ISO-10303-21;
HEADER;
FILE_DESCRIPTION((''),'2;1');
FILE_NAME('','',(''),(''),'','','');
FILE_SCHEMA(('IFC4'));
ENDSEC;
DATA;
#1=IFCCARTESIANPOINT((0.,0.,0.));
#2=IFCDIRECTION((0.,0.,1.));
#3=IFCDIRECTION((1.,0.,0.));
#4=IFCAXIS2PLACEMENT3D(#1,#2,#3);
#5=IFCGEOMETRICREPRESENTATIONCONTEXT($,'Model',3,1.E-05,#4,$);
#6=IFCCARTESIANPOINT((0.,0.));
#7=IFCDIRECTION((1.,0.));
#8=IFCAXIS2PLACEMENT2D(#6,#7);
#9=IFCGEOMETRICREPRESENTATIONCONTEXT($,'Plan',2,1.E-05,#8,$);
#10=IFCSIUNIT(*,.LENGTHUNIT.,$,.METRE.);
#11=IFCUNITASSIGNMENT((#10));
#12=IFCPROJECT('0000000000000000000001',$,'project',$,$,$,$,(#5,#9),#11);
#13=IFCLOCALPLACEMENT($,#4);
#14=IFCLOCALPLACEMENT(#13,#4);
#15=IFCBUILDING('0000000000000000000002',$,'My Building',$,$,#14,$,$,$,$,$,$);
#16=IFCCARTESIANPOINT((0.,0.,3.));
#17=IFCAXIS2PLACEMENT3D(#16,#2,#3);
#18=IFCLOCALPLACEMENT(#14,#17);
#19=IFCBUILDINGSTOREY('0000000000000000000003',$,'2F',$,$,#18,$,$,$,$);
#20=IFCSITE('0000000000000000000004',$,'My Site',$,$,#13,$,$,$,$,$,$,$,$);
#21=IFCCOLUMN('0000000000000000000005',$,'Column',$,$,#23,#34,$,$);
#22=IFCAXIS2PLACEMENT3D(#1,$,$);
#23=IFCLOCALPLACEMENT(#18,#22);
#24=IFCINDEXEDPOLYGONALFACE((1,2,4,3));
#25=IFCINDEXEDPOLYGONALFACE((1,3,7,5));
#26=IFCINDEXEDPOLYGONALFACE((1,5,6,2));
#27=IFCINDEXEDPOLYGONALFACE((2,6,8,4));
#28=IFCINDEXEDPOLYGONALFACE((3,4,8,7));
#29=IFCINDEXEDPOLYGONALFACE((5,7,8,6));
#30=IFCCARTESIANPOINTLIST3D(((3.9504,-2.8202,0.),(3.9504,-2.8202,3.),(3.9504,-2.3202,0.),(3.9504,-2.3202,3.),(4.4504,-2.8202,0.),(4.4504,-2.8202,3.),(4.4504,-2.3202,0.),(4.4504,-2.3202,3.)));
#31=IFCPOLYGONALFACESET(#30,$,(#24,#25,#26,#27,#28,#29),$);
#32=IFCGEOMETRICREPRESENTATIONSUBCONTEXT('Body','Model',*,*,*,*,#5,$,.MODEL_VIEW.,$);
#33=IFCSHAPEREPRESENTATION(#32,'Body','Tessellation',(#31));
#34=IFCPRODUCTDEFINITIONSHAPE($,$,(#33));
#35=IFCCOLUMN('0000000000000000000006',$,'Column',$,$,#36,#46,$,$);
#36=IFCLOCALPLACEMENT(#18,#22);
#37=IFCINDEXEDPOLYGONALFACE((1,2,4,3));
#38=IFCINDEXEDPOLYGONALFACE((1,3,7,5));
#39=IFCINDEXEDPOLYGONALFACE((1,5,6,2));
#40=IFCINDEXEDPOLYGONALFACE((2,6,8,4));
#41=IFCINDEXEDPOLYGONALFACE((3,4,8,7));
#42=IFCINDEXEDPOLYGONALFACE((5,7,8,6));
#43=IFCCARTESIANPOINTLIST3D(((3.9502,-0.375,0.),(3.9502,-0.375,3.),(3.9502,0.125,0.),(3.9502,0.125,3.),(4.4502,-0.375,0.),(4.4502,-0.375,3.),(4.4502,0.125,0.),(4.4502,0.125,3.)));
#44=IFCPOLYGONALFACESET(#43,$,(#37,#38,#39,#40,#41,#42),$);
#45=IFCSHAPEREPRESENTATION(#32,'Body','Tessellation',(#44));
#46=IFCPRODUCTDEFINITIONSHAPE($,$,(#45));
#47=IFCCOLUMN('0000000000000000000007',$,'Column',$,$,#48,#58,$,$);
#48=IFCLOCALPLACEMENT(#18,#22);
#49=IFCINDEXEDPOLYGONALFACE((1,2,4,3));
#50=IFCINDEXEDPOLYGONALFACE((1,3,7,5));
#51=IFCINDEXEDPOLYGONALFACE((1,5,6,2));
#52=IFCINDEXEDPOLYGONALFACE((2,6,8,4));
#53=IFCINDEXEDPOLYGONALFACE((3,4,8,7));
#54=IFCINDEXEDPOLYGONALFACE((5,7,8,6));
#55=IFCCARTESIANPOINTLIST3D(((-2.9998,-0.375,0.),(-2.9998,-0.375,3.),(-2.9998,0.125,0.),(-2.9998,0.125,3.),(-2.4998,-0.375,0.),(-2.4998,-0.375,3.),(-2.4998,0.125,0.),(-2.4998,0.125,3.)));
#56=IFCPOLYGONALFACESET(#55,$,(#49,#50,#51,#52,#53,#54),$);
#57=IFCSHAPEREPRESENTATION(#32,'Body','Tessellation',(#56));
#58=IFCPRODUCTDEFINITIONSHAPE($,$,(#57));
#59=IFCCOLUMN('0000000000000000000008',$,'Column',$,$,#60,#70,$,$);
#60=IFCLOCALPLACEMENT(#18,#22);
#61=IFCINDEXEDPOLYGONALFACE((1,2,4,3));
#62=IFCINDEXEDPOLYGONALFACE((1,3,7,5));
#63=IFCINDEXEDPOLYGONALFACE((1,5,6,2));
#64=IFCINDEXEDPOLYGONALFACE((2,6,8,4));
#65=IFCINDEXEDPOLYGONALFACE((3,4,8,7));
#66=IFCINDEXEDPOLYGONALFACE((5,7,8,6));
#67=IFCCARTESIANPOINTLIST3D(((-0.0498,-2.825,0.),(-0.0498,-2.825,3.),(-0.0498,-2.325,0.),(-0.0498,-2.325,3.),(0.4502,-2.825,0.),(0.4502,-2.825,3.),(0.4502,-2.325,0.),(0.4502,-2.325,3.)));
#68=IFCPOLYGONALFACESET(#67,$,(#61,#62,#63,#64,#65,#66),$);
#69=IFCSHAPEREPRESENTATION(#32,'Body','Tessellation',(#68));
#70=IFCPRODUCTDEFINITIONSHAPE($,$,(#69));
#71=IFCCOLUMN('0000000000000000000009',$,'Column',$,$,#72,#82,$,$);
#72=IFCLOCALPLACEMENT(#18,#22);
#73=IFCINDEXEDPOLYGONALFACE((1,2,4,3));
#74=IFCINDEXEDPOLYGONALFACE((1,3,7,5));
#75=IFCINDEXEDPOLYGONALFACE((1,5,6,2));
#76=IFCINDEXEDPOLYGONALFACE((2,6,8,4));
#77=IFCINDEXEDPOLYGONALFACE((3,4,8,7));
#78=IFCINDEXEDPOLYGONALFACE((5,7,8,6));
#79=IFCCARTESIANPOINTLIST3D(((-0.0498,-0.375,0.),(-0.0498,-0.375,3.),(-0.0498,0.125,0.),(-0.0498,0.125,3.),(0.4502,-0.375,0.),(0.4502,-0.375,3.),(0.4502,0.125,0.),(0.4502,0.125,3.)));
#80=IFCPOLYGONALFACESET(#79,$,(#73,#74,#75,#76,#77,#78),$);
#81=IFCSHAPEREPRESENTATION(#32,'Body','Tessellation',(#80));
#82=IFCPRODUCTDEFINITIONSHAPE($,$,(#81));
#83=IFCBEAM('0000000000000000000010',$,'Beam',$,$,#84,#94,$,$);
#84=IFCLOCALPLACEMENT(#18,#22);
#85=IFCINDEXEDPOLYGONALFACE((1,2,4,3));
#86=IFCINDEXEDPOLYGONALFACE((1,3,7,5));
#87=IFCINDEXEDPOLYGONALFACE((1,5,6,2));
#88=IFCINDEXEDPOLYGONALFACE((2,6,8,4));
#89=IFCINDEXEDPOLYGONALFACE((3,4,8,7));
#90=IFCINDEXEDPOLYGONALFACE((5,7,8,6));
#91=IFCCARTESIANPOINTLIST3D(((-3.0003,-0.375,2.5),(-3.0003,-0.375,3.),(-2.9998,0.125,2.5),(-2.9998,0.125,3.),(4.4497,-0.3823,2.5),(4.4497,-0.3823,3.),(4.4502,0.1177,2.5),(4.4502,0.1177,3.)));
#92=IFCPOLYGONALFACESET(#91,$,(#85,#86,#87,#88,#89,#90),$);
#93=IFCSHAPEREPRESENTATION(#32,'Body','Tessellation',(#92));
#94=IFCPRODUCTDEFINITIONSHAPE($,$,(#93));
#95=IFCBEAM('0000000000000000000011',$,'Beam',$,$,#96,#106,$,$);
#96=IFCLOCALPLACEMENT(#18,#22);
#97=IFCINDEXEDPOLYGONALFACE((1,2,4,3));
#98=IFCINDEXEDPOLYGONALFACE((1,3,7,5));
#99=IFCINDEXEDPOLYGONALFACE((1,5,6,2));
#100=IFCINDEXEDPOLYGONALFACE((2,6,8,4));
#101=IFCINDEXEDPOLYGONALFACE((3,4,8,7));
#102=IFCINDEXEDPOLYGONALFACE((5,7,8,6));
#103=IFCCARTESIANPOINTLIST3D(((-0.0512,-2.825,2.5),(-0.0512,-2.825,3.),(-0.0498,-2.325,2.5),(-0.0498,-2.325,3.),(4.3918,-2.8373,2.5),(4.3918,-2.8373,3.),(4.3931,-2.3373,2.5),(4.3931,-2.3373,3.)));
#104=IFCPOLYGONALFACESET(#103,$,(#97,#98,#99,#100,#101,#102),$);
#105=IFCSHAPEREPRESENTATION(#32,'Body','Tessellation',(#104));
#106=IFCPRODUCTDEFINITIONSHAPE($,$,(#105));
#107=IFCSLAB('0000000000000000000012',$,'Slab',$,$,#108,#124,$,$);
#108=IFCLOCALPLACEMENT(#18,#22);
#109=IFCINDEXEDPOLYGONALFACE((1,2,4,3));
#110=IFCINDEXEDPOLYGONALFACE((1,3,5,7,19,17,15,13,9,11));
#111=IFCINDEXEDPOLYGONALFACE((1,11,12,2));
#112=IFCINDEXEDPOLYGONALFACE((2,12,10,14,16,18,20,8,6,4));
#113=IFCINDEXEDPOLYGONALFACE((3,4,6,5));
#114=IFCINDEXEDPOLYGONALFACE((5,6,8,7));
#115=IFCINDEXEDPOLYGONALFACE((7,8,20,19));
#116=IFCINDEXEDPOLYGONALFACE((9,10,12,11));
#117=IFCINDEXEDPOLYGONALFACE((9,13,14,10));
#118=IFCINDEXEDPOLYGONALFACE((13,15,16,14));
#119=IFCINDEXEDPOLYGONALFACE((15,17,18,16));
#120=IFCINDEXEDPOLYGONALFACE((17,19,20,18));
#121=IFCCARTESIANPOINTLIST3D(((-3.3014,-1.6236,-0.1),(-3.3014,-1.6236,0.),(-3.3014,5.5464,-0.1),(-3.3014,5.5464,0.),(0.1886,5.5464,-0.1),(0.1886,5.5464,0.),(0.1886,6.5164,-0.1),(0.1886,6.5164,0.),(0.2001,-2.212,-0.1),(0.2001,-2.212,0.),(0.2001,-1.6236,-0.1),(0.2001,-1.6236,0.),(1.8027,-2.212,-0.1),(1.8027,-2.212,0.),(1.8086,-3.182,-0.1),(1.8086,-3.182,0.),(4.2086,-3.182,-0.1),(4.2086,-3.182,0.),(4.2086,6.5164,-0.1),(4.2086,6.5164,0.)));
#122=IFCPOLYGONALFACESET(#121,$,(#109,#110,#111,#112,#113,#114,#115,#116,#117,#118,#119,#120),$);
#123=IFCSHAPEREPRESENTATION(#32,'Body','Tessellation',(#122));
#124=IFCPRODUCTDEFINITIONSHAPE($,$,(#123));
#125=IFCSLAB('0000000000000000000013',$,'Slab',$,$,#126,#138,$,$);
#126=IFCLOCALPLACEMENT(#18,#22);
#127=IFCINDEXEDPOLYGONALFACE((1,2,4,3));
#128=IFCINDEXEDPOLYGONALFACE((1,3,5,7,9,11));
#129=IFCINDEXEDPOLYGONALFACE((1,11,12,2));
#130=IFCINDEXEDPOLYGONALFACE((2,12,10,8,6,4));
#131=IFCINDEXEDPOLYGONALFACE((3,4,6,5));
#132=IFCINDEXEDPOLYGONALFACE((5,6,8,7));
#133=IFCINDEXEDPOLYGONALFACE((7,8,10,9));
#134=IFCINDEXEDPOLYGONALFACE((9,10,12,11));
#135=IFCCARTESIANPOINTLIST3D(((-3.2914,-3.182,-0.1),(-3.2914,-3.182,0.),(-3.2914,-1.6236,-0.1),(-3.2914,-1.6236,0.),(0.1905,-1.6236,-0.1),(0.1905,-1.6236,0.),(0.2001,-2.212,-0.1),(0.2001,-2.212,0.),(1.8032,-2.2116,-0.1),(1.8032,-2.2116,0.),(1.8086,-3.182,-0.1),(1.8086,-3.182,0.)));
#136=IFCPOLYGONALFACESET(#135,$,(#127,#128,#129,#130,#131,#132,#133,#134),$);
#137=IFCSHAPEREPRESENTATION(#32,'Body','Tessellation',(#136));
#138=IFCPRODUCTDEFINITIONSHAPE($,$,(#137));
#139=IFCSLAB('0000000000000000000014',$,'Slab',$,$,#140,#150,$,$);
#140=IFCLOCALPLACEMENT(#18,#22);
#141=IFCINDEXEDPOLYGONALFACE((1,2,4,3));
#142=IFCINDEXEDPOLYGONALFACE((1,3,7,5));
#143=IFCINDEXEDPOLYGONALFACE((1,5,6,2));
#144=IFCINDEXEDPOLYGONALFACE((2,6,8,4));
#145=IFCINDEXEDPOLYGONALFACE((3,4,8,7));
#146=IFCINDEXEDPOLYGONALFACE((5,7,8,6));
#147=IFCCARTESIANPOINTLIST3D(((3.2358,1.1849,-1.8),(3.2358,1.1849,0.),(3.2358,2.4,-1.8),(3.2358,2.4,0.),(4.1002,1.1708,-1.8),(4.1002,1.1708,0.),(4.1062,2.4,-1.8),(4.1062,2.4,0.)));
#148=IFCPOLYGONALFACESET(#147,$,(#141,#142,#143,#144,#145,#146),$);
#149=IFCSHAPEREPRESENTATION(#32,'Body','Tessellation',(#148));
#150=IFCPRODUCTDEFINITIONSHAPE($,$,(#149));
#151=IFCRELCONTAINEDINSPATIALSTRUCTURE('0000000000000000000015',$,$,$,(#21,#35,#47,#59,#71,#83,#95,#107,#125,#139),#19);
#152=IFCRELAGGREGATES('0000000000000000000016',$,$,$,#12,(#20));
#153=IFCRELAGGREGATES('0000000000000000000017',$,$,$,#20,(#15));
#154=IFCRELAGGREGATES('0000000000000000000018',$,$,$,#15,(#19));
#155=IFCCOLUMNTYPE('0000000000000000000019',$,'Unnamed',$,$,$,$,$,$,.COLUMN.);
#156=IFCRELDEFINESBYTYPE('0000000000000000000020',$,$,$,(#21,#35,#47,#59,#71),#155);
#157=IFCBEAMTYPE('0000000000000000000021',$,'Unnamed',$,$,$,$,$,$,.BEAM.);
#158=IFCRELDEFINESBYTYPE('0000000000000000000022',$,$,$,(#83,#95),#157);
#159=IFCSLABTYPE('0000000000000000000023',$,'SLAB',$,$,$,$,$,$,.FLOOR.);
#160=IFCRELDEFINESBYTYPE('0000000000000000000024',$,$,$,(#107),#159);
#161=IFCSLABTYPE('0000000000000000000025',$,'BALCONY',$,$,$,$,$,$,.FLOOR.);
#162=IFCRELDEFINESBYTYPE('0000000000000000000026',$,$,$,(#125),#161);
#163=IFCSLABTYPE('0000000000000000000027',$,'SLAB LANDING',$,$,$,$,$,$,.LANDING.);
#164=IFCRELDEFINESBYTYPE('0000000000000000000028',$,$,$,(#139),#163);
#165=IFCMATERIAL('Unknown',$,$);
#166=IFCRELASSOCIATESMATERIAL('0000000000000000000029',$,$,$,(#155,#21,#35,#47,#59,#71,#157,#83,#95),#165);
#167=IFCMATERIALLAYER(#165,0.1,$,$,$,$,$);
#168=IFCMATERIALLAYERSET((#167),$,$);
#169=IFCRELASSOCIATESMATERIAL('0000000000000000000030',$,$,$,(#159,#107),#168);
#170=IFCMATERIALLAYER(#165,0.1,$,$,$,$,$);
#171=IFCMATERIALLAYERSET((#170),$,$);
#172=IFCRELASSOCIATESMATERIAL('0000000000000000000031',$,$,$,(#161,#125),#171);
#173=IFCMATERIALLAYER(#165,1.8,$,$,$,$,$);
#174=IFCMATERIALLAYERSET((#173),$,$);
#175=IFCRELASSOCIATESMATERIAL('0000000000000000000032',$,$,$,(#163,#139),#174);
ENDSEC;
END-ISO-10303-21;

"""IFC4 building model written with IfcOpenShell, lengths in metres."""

from ifc_helpers import new_model, si_unit, frame, origin_with_axes, origin_2d_with_axis, place, context, subcontext, project, spatial, indexed_curve, rectangle, outline, extrude, material, layer, layer_set, layer_usage, material_profile, profile_set, profile_usage, type_object, element, save


model = new_model("IFC4")

# Units and contexts
model_context = context("Model", 3, precision=1e-05, world=origin_with_axes())
plan_context = context("Plan", 2, precision=1e-05, world=origin_2d_with_axis())
body_context_1 = subcontext(model_context, "Body", "Model", "MODEL_VIEW")
ifc_project = project(units=[si_unit("LENGTHUNIT", "METRE")], contexts=[model_context, plan_context])

# Site, building, storey
site_placement = place(None, origin_with_axes())
site = spatial("IfcSite", under=ifc_project, at=site_placement, Name="My Site")
building_placement = place(site_placement, origin_with_axes())
building = spatial("IfcBuilding", under=site, at=building_placement, Name="My Building")
storey_placement = place(building_placement, frame((0.0, 0.0, 3.0), z_axis=(0.0, 0.0, 1.0), x_axis=(1.0, 0.0, 0.0)))
storey = spatial("IfcBuildingStorey", under=building, at=storey_placement, Name="2F")

# Columns
ifc_material_1 = material(Name="Unknown")
ifc_material_profile_1 = material_profile(ifc_material_1, rectangle(XDim=0.5, YDim=0.5))
ifc_profile_set_1 = profile_set([ifc_material_profile_1])
ifc_profile_usage_1 = profile_usage(ifc_profile_set_1, cardinal=7)
column_type = type_object("IfcColumnType", Name="Unnamed", PredefinedType="COLUMN", material=ifc_profile_set_1)
column_1_placement = place(storey_placement, frame((4.4504, -2.3202, 0.0), z_axis=(0.0, 0.0, 1.0), x_axis=(1.0, 0.0, 0.0)))
element("IfcColumn", 1, at=column_1_placement, inside=storey, type_object=column_type, material=ifc_profile_usage_1, Name="Column", context=body_context_1, shape_type="SweptSolid", body=[
    extrude(rectangle(XDim=0.5, YDim=0.5), frame((-0.25, -0.25, 0.0), z_axis=(0.0, 0.0, 1.0), x_axis=(1.0, 0.0, 0.0)), (0.0, 0.0, 1.0), 3.0),
])
ifc_profile_usage_2 = profile_usage(ifc_profile_set_1, cardinal=7)
column_2_placement = place(storey_placement, frame((4.4502, 0.125, 0.0), z_axis=(0.0, 0.0, 1.0), x_axis=(1.0, 0.0, 0.0)))
element("IfcColumn", 2, at=column_2_placement, inside=storey, type_object=column_type, material=ifc_profile_usage_2, Name="Column", context=body_context_1, shape_type="SweptSolid", body=[
    extrude(rectangle(XDim=0.5, YDim=0.5), frame((-0.25, -0.25, 0.0), z_axis=(0.0, 0.0, 1.0), x_axis=(1.0, 0.0, 0.0)), (0.0, 0.0, 1.0), 3.0),
])
ifc_profile_usage_3 = profile_usage(ifc_profile_set_1, cardinal=7)
column_3_placement = place(storey_placement, frame((-2.4998, 0.125, 0.0), z_axis=(0.0, 0.0, 1.0), x_axis=(1.0, 0.0, 0.0)))
element("IfcColumn", 3, at=column_3_placement, inside=storey, type_object=column_type, material=ifc_profile_usage_3, Name="Column", context=body_context_1, shape_type="SweptSolid", body=[
    extrude(rectangle(XDim=0.5, YDim=0.5), frame((-0.25, -0.25, 0.0), z_axis=(0.0, 0.0, 1.0), x_axis=(1.0, 0.0, 0.0)), (0.0, 0.0, 1.0), 3.0),
])
ifc_profile_usage_4 = profile_usage(ifc_profile_set_1, cardinal=7)
column_4_placement = place(storey_placement, frame((0.4502, -2.325, 0.0), z_axis=(0.0, 0.0, 1.0), x_axis=(1.0, 0.0, 0.0)))
element("IfcColumn", 4, at=column_4_placement, inside=storey, type_object=column_type, material=ifc_profile_usage_4, Name="Column", context=body_context_1, shape_type="SweptSolid", body=[
    extrude(rectangle(XDim=0.5, YDim=0.5), frame((-0.25, -0.25, 0.0), z_axis=(0.0, 0.0, 1.0), x_axis=(1.0, 0.0, 0.0)), (0.0, 0.0, 1.0), 3.0),
])
ifc_profile_usage_5 = profile_usage(ifc_profile_set_1, cardinal=7)
column_5_placement = place(storey_placement, frame((0.4502, 0.125, 0.0), z_axis=(0.0, 0.0, 1.0), x_axis=(1.0, 0.0, 0.0)))
element("IfcColumn", 5, at=column_5_placement, inside=storey, type_object=column_type, material=ifc_profile_usage_5, Name="Column", context=body_context_1, shape_type="SweptSolid", body=[
    extrude(rectangle(XDim=0.5, YDim=0.5), frame((-0.25, -0.25, 0.0), z_axis=(0.0, 0.0, 1.0), x_axis=(1.0, 0.0, 0.0)), (0.0, 0.0, 1.0), 3.0),
])

# Beams
ifc_material_profile_2 = material_profile(ifc_material_1, rectangle(XDim=0.5, YDim=0.5))
ifc_profile_set_2 = profile_set([ifc_material_profile_2])
ifc_profile_usage_6 = profile_usage(ifc_profile_set_2, cardinal=7)
beam_type = type_object("IfcBeamType", Name="Unnamed", PredefinedType="BEAM", material=ifc_profile_set_2)
beam_1_placement = place(storey_placement, frame((-2.9998, 0.125, 3.0), z_axis=(1.0, -0.000973, 0.0), x_axis=(0.000973, 1.0, 0.0)))
element("IfcBeam", 6, at=beam_1_placement, inside=storey, type_object=beam_type, material=ifc_profile_usage_6, Name="Beam", context=body_context_1, shape_type="SweptSolid", body=[
    extrude(rectangle(XDim=0.5, YDim=0.5), frame((-0.25, -0.25, 0.0), z_axis=(0.0, 0.0, 1.0), x_axis=(1.0, 0.0, 0.0)), (0.0, 0.0, 1.0), 7.45),
])
ifc_profile_usage_7 = profile_usage(ifc_profile_set_2, cardinal=7)
beam_2_placement = place(storey_placement, frame((-0.0498, -2.325, 3.0), z_axis=(0.999996, -0.002764, 0.0), x_axis=(0.002764, 0.999996, 0.0)))
element("IfcBeam", 7, at=beam_2_placement, inside=storey, type_object=beam_type, material=ifc_profile_usage_7, Name="Beam", context=body_context_1, shape_type="SweptSolid", body=[
    extrude(rectangle(XDim=0.5, YDim=0.5), frame((-0.25, -0.25, 0.0), z_axis=(0.0, 0.0, 1.0), x_axis=(1.0, 0.0, 0.0)), (0.0, 0.0, 1.0), 4.4429),
])

# Slabs
ifc_layer_1 = layer(ifc_material_1, 0.1)
ifc_layer_set_1 = layer_set([ifc_layer_1])
ifc_layer_usage_1 = layer_usage(ifc_layer_set_1, "AXIS3", "POSITIVE", -0.1)
slab_type_1 = type_object("IfcSlabType", Name="SLAB", PredefinedType="FLOOR", material=ifc_layer_set_1)
slab_1_placement = place(storey_placement, frame((4.2086, -3.182, 0.0), z_axis=(0.0, 0.0, 1.0), x_axis=(1.0, 0.0, 0.0)))
element("IfcSlab", 8, at=slab_1_placement, inside=storey, type_object=slab_type_1, material=ifc_layer_usage_1, Name="Slab", context=body_context_1, shape_type="SweptSolid", body=[
    extrude(outline(indexed_curve([(0.0, 0.0), (0.0, 9.6984), (-4.02, 9.6984), (-4.02, 8.7284), (-7.51, 8.7284), (-7.51, 1.5584), (-4.0085, 1.5584), (-4.0085, 0.97), (-2.4059, 0.97), (-2.4, 0.0), (0.0, 0.0)])), frame((0.0, 0.0, -0.1), z_axis=(0.0, 0.0, 1.0), x_axis=(1.0, 0.0, 0.0)), (0.0, 0.0, 1.0), 0.1),
])
ifc_layer_2 = layer(ifc_material_1, 0.1)
ifc_layer_set_2 = layer_set([ifc_layer_2])
ifc_layer_usage_2 = layer_usage(ifc_layer_set_2, "AXIS3", "POSITIVE", -0.1)
slab_type_2 = type_object("IfcSlabType", Name="BALCONY", PredefinedType="FLOOR", material=ifc_layer_set_2)
slab_2_placement = place(storey_placement, frame((1.8086, -3.182, 0.0), z_axis=(0.0, 0.0, 1.0), x_axis=(1.0, 0.0, 0.0)))
element("IfcSlab", 9, at=slab_2_placement, inside=storey, type_object=slab_type_2, material=ifc_layer_usage_2, Name="Slab", context=body_context_1, shape_type="SweptSolid", body=[
    extrude(outline(indexed_curve([(0.0, 0.0), (-5.1, 0.0), (-5.1, 1.5584), (-1.6181, 1.5584), (-1.6085, 0.97), (-0.0054, 0.9704), (0.0, 0.0)])), frame((0.0, 0.0, -0.1), z_axis=(0.0, 0.0, 1.0), x_axis=(1.0, 0.0, 0.0)), (0.0, 0.0, 1.0), 0.1),
])
ifc_layer_3 = layer(ifc_material_1, 1.8)
ifc_layer_set_3 = layer_set([ifc_layer_3])
ifc_layer_usage_3 = layer_usage(ifc_layer_set_3, "AXIS3", "POSITIVE", -1.8)
slab_type_3 = type_object("IfcSlabType", Name="SLAB LANDING", PredefinedType="LANDING", material=ifc_layer_set_3)
slab_3_placement = place(storey_placement, frame((3.2358, 1.1849, 0.0), z_axis=(0.0, 0.0, 1.0), x_axis=(1.0, 0.0, 0.0)))
element("IfcSlab", 10, at=slab_3_placement, inside=storey, type_object=slab_type_3, material=ifc_layer_usage_3, Name="Slab", context=body_context_1, shape_type="SweptSolid", body=[
    extrude(outline(indexed_curve([(0.0, 0.0), (0.0, 1.2151), (0.8704, 1.2151), (0.8645, -0.0141), (0.0, 0.0)])), frame((0.0, 0.0, -1.8), z_axis=(0.0, 0.0, 1.0), x_axis=(1.0, 0.0, 0.0)), (0.0, 0.0, 1.0), 1.8),
])

save(model, "model.ifc")
